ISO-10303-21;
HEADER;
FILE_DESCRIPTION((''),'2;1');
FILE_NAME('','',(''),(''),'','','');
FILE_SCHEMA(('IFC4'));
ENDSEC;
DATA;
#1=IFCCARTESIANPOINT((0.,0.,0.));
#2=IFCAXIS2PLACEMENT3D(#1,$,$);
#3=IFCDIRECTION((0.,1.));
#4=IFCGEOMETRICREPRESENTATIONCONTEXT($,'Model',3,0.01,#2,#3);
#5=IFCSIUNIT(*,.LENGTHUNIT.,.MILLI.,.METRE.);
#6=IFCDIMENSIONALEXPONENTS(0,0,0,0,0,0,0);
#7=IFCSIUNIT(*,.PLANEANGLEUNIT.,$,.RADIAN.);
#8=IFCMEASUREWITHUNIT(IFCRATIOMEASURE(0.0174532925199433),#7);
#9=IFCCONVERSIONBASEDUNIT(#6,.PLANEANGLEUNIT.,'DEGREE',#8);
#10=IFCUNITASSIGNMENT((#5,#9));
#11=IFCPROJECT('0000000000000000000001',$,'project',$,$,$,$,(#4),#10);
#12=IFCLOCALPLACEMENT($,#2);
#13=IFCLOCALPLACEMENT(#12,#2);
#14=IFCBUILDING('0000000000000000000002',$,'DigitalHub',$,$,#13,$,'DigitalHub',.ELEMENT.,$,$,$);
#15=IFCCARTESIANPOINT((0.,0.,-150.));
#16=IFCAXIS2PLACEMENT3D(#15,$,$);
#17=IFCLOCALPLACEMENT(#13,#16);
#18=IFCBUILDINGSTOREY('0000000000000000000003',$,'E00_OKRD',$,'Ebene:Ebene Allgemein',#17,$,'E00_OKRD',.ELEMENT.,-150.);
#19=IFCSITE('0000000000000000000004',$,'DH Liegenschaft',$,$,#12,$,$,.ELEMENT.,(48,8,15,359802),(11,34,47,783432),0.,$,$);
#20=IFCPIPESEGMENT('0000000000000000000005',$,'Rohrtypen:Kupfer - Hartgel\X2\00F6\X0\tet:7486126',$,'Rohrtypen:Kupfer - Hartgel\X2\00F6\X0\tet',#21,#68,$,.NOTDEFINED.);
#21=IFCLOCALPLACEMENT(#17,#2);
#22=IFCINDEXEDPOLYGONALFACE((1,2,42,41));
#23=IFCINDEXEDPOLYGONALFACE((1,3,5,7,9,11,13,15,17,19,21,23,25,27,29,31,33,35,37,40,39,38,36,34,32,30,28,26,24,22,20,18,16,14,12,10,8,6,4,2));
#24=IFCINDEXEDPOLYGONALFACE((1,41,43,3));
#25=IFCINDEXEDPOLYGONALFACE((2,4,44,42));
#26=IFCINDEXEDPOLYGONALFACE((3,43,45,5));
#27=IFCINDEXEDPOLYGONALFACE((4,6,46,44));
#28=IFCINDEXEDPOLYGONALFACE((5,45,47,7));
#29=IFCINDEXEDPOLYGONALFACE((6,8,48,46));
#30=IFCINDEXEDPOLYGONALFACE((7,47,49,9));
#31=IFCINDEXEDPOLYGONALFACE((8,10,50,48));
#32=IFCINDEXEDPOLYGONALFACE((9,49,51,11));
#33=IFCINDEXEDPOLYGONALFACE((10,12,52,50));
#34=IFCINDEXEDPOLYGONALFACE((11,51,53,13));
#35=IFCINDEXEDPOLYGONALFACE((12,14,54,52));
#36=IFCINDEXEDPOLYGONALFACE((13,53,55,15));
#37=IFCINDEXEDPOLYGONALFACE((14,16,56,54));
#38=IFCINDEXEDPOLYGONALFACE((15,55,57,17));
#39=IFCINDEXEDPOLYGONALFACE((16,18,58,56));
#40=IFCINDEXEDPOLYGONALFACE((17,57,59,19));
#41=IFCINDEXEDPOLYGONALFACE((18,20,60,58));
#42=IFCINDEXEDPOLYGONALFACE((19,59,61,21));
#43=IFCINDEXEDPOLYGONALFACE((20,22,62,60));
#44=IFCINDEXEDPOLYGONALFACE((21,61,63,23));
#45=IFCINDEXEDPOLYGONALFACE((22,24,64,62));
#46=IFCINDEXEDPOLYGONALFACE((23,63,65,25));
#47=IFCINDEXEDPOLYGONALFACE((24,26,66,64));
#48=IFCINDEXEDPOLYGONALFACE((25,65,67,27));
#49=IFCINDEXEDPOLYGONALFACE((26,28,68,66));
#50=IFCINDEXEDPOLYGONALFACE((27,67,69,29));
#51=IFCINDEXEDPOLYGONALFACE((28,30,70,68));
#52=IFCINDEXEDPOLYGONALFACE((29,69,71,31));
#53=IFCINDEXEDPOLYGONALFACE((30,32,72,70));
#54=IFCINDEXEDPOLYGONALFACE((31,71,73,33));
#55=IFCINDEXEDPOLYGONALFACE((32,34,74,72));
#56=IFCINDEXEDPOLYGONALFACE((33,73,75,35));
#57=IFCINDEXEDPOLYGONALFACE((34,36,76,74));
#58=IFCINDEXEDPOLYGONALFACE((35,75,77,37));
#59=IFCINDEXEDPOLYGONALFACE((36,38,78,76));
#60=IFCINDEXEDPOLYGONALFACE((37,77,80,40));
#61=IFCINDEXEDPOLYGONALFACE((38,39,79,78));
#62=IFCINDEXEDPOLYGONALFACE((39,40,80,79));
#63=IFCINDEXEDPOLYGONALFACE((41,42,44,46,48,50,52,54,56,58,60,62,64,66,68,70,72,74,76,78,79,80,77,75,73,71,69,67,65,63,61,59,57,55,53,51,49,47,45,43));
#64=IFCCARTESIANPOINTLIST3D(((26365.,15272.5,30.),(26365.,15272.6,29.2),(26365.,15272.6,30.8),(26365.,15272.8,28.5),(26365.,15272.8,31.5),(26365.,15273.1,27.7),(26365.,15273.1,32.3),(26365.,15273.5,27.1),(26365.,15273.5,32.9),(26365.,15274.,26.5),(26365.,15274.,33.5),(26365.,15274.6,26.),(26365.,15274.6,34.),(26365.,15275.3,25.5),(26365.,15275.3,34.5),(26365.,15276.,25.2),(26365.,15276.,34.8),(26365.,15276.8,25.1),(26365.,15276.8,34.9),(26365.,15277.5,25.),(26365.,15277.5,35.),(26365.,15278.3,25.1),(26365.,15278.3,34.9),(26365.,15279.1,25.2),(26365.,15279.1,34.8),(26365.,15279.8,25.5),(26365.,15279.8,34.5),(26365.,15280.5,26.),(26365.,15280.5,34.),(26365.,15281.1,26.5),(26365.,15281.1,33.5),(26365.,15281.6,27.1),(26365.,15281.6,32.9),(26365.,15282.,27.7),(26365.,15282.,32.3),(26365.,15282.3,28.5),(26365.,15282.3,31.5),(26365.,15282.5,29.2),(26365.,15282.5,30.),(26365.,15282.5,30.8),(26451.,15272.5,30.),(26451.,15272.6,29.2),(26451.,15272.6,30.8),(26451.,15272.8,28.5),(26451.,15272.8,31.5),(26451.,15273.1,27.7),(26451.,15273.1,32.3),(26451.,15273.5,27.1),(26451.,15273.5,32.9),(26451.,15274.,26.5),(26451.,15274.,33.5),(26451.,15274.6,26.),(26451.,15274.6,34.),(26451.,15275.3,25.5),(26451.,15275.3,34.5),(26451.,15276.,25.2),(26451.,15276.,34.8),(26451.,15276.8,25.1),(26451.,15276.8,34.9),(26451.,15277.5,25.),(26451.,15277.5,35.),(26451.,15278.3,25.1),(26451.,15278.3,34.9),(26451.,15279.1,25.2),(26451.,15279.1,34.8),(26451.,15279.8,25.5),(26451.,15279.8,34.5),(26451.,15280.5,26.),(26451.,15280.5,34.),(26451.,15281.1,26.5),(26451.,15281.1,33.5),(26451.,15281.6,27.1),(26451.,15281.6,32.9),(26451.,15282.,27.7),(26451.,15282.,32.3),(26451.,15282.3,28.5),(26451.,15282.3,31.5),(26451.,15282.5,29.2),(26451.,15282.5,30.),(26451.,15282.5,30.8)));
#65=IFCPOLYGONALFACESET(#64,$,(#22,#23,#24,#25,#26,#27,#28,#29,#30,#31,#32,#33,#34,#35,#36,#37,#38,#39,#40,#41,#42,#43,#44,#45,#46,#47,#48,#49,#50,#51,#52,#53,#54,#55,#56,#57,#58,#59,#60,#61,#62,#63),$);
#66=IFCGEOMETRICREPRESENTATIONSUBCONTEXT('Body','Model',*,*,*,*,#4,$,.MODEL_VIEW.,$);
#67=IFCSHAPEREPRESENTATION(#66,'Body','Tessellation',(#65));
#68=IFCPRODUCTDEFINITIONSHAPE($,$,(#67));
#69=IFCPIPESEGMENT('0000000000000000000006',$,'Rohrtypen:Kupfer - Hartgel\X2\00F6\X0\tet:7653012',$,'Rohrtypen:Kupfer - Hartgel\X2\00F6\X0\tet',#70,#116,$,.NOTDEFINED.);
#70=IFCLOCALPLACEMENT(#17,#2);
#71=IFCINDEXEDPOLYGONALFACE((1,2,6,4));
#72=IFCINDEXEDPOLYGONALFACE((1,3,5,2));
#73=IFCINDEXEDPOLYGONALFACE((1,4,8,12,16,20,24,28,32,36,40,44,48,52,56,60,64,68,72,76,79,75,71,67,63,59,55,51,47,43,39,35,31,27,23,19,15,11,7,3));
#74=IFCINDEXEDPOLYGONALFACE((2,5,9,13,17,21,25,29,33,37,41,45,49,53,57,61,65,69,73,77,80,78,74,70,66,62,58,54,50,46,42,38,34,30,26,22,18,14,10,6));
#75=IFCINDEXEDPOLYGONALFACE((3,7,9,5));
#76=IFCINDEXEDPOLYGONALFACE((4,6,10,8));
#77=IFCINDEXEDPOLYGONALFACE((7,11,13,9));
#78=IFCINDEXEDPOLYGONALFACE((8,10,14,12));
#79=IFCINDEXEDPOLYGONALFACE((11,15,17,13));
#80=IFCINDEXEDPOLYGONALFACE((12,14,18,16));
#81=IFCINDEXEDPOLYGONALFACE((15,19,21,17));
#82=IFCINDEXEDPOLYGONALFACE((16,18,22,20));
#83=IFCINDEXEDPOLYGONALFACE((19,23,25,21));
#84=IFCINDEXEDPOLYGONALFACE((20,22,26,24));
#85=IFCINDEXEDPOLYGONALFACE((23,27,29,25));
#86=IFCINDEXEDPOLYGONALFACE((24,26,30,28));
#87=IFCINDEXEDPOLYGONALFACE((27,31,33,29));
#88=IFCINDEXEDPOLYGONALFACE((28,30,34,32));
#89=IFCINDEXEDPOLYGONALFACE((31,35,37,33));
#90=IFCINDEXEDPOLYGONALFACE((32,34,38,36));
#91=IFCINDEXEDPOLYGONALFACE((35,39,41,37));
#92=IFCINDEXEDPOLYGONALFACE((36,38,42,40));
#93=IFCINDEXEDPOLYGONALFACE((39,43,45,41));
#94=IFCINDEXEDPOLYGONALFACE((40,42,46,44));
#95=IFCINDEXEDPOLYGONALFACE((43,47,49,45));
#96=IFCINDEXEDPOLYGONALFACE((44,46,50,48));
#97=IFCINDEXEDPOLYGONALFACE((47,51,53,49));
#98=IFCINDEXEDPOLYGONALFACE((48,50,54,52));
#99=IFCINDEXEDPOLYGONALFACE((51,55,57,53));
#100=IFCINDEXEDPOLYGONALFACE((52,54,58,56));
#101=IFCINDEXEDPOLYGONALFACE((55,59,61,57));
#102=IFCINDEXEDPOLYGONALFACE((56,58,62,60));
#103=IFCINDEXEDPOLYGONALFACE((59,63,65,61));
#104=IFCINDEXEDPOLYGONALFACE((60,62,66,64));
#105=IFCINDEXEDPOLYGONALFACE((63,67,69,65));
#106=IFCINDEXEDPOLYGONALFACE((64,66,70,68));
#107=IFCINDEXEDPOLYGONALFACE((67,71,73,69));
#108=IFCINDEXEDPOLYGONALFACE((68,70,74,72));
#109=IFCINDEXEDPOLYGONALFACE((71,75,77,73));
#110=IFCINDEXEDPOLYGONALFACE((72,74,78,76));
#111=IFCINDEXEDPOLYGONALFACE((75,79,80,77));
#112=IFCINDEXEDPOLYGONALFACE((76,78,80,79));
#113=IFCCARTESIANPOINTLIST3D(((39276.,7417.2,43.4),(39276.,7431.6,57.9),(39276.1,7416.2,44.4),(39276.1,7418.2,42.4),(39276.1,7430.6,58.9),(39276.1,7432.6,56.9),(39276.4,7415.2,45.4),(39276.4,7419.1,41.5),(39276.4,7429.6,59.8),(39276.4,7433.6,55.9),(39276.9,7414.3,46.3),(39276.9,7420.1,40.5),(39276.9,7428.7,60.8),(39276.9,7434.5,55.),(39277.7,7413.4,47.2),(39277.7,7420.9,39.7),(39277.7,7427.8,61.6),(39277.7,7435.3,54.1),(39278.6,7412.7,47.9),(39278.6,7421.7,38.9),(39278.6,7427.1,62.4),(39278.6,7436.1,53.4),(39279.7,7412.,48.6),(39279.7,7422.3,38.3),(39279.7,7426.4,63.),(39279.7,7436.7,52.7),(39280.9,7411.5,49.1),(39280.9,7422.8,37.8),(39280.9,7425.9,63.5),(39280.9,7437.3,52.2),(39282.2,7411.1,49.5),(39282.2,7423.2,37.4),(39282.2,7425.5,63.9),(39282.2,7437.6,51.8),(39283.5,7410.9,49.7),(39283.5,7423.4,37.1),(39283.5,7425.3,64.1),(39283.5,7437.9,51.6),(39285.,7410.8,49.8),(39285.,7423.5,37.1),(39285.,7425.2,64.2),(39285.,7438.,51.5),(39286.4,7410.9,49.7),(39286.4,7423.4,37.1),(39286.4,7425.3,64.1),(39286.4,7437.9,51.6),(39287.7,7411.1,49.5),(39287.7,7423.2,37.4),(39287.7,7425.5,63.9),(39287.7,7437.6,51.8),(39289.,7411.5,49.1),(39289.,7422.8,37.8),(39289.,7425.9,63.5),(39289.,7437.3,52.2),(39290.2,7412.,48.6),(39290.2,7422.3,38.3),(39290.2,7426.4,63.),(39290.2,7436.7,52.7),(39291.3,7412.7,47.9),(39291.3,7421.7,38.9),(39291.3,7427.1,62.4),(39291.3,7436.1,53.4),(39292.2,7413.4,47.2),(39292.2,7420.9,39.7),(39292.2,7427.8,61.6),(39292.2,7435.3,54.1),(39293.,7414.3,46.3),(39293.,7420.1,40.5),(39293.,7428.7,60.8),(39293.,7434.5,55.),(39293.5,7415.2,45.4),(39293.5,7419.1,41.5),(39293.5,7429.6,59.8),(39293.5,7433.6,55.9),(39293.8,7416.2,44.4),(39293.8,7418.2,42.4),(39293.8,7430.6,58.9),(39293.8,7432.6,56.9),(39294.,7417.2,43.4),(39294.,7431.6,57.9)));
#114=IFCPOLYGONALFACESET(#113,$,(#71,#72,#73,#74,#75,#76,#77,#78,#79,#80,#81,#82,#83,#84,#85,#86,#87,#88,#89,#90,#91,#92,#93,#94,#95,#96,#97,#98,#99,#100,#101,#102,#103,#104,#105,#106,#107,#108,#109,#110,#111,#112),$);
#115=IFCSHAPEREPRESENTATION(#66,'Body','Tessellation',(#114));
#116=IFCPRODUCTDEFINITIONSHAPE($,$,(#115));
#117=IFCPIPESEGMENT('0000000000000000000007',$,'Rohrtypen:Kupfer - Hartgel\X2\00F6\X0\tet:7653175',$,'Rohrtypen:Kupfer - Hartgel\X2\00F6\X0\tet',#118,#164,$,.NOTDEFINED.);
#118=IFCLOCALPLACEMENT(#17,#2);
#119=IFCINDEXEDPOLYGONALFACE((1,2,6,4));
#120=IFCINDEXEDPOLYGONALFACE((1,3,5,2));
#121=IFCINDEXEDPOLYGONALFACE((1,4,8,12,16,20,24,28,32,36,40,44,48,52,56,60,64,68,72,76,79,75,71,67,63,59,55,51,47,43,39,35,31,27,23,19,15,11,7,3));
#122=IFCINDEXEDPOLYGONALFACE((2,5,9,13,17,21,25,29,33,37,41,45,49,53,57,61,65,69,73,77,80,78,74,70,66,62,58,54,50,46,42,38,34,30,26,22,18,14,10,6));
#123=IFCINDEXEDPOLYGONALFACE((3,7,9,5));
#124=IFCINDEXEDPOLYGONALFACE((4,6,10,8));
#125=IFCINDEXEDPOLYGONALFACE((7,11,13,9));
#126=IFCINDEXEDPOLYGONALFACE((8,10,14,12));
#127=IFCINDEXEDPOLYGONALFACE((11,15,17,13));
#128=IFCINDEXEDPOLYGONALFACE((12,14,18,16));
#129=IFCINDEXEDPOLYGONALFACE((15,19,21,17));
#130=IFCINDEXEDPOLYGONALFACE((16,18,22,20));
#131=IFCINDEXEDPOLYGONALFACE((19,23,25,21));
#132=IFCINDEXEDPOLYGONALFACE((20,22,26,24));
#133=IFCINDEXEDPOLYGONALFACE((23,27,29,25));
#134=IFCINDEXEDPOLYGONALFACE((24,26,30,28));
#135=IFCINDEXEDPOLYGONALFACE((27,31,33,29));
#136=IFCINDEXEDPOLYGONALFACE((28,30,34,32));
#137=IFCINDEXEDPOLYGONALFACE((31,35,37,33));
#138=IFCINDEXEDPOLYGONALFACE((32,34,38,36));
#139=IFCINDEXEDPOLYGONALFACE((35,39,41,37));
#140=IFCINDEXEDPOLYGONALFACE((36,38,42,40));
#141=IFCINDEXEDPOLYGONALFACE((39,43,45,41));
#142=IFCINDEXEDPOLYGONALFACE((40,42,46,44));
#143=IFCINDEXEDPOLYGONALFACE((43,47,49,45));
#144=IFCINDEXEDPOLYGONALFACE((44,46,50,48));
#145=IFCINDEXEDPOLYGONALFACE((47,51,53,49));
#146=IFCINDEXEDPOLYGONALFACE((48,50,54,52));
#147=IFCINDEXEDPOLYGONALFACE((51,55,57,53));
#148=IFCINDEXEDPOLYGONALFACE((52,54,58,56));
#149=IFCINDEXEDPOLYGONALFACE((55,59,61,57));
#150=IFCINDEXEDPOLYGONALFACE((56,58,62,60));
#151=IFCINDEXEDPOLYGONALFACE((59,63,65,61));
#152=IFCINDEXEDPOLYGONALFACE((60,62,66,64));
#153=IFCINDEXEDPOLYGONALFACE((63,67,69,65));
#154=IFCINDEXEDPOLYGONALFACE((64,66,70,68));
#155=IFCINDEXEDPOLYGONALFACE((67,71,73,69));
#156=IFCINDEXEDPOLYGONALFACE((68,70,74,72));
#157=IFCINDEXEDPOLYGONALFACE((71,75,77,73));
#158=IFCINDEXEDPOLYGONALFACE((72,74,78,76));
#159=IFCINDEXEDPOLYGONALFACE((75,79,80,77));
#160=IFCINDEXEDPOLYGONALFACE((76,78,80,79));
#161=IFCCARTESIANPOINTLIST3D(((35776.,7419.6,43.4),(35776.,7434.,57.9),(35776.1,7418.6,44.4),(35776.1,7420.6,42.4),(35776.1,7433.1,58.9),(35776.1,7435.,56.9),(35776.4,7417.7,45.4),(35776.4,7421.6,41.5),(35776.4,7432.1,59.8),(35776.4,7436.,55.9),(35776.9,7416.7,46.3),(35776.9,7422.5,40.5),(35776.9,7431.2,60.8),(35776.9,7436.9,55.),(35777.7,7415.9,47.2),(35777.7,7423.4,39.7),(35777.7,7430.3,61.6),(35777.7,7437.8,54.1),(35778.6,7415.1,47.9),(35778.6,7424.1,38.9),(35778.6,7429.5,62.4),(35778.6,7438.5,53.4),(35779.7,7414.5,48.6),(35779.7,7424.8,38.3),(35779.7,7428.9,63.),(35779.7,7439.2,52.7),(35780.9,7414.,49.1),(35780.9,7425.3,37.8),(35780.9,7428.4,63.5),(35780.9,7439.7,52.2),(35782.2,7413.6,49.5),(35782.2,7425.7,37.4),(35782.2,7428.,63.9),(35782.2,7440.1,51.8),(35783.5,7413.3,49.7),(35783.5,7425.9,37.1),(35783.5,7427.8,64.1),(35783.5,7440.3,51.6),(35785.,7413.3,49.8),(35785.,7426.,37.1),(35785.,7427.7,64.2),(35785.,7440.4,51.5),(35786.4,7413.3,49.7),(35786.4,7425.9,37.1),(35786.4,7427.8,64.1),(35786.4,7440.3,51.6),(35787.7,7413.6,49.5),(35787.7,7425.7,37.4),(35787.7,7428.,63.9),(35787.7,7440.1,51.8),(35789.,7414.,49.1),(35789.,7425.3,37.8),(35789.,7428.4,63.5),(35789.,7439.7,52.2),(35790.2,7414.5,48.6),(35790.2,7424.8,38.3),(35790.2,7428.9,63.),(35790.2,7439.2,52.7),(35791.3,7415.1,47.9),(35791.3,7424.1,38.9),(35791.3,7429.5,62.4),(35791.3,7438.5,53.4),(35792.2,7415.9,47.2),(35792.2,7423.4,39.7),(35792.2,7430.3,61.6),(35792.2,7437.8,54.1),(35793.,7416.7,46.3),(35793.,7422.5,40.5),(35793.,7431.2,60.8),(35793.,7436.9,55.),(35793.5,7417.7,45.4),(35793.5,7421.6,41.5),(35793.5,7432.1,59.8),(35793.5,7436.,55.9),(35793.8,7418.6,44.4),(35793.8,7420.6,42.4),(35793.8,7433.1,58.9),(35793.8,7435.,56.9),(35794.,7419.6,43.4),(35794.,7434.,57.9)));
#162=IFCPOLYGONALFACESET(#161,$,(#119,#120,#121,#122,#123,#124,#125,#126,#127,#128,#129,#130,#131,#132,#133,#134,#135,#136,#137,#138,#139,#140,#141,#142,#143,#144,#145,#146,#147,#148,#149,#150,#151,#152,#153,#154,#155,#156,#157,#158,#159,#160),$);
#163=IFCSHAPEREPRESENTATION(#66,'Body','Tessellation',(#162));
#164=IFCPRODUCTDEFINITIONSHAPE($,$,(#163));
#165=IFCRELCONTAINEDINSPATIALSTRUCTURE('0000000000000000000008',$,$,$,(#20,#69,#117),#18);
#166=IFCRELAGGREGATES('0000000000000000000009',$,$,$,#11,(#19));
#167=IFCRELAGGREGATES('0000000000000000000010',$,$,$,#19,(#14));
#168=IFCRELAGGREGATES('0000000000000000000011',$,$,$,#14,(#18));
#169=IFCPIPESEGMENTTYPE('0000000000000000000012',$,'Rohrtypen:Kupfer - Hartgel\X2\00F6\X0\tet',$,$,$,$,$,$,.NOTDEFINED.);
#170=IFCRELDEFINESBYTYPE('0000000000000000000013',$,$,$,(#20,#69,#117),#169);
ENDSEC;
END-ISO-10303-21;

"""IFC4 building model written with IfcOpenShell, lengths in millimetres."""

from ifc_helpers import new_model, entity, si_unit, converted_unit, direction, frame, origin, place, context, subcontext, project, spatial, indexed_curve, outline, extrude, type_object, element, save


model = new_model("IFC4")

# Units and contexts
model_context = context("Model", 3, precision=0.01, world=origin(), true_north=direction((0.0, 1.0)))
body_context = subcontext(model_context, "Body", "Model", "MODEL_VIEW")
ifc_project = project(units=[si_unit("LENGTHUNIT", "METRE", prefix="MILLI"), converted_unit("PLANEANGLEUNIT", "DEGREE", entity("IfcRatioMeasure", 0.0174532925199433), si_unit("PLANEANGLEUNIT", "RADIAN"), dimensions=[0, 0, 0, 0, 0, 0, 0])], contexts=[model_context])

# Site, building, storey
site_placement = place(None, origin())
site = spatial("IfcSite", under=ifc_project, at=site_placement, Name="DH Liegenschaft", CompositionType="ELEMENT", RefLatitude=(48, 8, 15, 359802), RefLongitude=(11, 34, 47, 783432), RefElevation=0.0)
building_placement = place(site_placement, origin())
building = spatial("IfcBuilding", under=site, at=building_placement, Name="DigitalHub", LongName="DigitalHub", CompositionType="ELEMENT")
storey_placement = place(building_placement, frame((0.0, 0.0, -150.0)))
storey = spatial("IfcBuildingStorey", under=building, at=storey_placement, Name="E00_OKRD", ObjectType="Ebene:Ebene Allgemein", LongName="E00_OKRD", CompositionType="ELEMENT", Elevation=-150.0)

# Pipe segments
pipe_segment_type = type_object("IfcPipeSegmentType", Name="Rohrtypen:Kupfer - Hartgelötet", PredefinedType="NOTDEFINED")
pipe_segment_1_placement = place(storey_placement, frame((26365.0, 15270.9, 23.4)))
element("IfcPipeSegment", 1, at=pipe_segment_1_placement, inside=storey, type_object=pipe_segment_type, Name="Rohrtypen:Kupfer - Hartgelötet:7486126", ObjectType="Rohrtypen:Kupfer - Hartgelötet", PredefinedType="NOTDEFINED", context=body_context, shape_type="SweptSolid", body=[
    extrude(outline(indexed_curve([(5.0, 0.0), (4.9, 0.8), (4.8, 1.5), (4.5, 2.3), (4.0, 2.9), (3.5, 3.5), (2.9, 4.0), (2.3, 4.5), (1.5, 4.8), (0.8, 4.9), (0.0, 5.0), (-0.8, 4.9), (-1.5, 4.8), (-2.3, 4.5), (-2.9, 4.0), (-3.5, 3.5), (-4.0, 2.9), (-4.5, 2.3), (-4.8, 1.5), (-4.9, 0.8), (-5.0, 0.0), (-4.9, -0.8), (-4.8, -1.5), (-4.5, -2.3), (-4.0, -2.9), (-3.5, -3.5), (-2.9, -4.0), (-2.3, -4.5), (-1.5, -4.8), (-0.8, -4.9), (0.0, -5.0), (0.8, -4.9), (1.5, -4.8), (2.3, -4.5), (2.9, -4.0), (3.5, -3.5), (4.0, -2.9), (4.5, -2.3), (4.8, -1.5), (4.9, -0.8), (5.0, 0.0)], self_intersect=False)), frame((0.0, 6.6, 6.6), z_axis=(1.0, 0.0, 0.0), x_axis=(0.0, 1.0, 0.0)), (0.0, 0.0, 1.0), 86.0),
])
pipe_segment_2_placement = place(storey_placement, frame((39274.4, 7409.2, 35.5)))
element("IfcPipeSegment", 2, at=pipe_segment_2_placement, inside=storey, type_object=pipe_segment_type, Name="Rohrtypen:Kupfer - Hartgelötet:7653012", ObjectType="Rohrtypen:Kupfer - Hartgelötet", PredefinedType="NOTDEFINED", context=body_context, shape_type="SweptSolid", body=[
    extrude(outline(indexed_curve([(9.0, 0.0), (8.9, 1.4), (8.6, 2.8), (8.0, 4.1), (7.3, 5.3), (6.4, 6.4), (5.3, 7.3), (4.1, 8.0), (2.8, 8.6), (1.4, 8.9), (0.0, 9.0), (-1.4, 8.9), (-2.8, 8.6), (-4.1, 8.0), (-5.3, 7.3), (-6.4, 6.4), (-7.3, 5.3), (-8.0, 4.1), (-8.6, 2.8), (-8.9, 1.4), (-9.0, 0.0), (-8.9, -1.4), (-8.6, -2.8), (-8.0, -4.1), (-7.3, -5.3), (-6.4, -6.4), (-5.3, -7.3), (-4.1, -8.0), (-2.8, -8.6), (-1.4, -8.9), (0.0, -9.0), (1.4, -8.9), (2.8, -8.6), (4.1, -8.0), (5.3, -7.3), (6.4, -6.4), (7.3, -5.3), (8.0, -4.1), (8.6, -2.8), (8.9, -1.4), (9.0, 0.0)], self_intersect=False)), frame((10.6, 8.0, 8.0), z_axis=(0.0, 0.707107, 0.707107), x_axis=(1.0, 0.0, 0.0)), (0.0, 0.0, 1.0), 20.4),
])
pipe_segment_3_placement = place(storey_placement, frame((35774.4, 7411.7, 35.5)))
element("IfcPipeSegment", 3, at=pipe_segment_3_placement, inside=storey, type_object=pipe_segment_type, Name="Rohrtypen:Kupfer - Hartgelötet:7653175", ObjectType="Rohrtypen:Kupfer - Hartgelötet", PredefinedType="NOTDEFINED", context=body_context, shape_type="SweptSolid", body=[
    extrude(outline(indexed_curve([(9.0, 0.0), (8.9, 1.4), (8.6, 2.8), (8.0, 4.1), (7.3, 5.3), (6.4, 6.4), (5.3, 7.3), (4.1, 8.0), (2.8, 8.6), (1.4, 8.9), (0.0, 9.0), (-1.4, 8.9), (-2.8, 8.6), (-4.1, 8.0), (-5.3, 7.3), (-6.4, 6.4), (-7.3, 5.3), (-8.0, 4.1), (-8.6, 2.8), (-8.9, 1.4), (-9.0, 0.0), (-8.9, -1.4), (-8.6, -2.8), (-8.0, -4.1), (-7.3, -5.3), (-6.4, -6.4), (-5.3, -7.3), (-4.1, -8.0), (-2.8, -8.6), (-1.4, -8.9), (0.0, -9.0), (1.4, -8.9), (2.8, -8.6), (4.1, -8.0), (5.3, -7.3), (6.4, -6.4), (7.3, -5.3), (8.0, -4.1), (8.6, -2.8), (8.9, -1.4), (9.0, 0.0)], self_intersect=False)), frame((10.6, 8.0, 8.0), z_axis=(0.0, 0.707107, 0.707107), x_axis=(1.0, 0.0, 0.0)), (0.0, 0.0, 1.0), 20.4),
])

save(model, "model.ifc")
